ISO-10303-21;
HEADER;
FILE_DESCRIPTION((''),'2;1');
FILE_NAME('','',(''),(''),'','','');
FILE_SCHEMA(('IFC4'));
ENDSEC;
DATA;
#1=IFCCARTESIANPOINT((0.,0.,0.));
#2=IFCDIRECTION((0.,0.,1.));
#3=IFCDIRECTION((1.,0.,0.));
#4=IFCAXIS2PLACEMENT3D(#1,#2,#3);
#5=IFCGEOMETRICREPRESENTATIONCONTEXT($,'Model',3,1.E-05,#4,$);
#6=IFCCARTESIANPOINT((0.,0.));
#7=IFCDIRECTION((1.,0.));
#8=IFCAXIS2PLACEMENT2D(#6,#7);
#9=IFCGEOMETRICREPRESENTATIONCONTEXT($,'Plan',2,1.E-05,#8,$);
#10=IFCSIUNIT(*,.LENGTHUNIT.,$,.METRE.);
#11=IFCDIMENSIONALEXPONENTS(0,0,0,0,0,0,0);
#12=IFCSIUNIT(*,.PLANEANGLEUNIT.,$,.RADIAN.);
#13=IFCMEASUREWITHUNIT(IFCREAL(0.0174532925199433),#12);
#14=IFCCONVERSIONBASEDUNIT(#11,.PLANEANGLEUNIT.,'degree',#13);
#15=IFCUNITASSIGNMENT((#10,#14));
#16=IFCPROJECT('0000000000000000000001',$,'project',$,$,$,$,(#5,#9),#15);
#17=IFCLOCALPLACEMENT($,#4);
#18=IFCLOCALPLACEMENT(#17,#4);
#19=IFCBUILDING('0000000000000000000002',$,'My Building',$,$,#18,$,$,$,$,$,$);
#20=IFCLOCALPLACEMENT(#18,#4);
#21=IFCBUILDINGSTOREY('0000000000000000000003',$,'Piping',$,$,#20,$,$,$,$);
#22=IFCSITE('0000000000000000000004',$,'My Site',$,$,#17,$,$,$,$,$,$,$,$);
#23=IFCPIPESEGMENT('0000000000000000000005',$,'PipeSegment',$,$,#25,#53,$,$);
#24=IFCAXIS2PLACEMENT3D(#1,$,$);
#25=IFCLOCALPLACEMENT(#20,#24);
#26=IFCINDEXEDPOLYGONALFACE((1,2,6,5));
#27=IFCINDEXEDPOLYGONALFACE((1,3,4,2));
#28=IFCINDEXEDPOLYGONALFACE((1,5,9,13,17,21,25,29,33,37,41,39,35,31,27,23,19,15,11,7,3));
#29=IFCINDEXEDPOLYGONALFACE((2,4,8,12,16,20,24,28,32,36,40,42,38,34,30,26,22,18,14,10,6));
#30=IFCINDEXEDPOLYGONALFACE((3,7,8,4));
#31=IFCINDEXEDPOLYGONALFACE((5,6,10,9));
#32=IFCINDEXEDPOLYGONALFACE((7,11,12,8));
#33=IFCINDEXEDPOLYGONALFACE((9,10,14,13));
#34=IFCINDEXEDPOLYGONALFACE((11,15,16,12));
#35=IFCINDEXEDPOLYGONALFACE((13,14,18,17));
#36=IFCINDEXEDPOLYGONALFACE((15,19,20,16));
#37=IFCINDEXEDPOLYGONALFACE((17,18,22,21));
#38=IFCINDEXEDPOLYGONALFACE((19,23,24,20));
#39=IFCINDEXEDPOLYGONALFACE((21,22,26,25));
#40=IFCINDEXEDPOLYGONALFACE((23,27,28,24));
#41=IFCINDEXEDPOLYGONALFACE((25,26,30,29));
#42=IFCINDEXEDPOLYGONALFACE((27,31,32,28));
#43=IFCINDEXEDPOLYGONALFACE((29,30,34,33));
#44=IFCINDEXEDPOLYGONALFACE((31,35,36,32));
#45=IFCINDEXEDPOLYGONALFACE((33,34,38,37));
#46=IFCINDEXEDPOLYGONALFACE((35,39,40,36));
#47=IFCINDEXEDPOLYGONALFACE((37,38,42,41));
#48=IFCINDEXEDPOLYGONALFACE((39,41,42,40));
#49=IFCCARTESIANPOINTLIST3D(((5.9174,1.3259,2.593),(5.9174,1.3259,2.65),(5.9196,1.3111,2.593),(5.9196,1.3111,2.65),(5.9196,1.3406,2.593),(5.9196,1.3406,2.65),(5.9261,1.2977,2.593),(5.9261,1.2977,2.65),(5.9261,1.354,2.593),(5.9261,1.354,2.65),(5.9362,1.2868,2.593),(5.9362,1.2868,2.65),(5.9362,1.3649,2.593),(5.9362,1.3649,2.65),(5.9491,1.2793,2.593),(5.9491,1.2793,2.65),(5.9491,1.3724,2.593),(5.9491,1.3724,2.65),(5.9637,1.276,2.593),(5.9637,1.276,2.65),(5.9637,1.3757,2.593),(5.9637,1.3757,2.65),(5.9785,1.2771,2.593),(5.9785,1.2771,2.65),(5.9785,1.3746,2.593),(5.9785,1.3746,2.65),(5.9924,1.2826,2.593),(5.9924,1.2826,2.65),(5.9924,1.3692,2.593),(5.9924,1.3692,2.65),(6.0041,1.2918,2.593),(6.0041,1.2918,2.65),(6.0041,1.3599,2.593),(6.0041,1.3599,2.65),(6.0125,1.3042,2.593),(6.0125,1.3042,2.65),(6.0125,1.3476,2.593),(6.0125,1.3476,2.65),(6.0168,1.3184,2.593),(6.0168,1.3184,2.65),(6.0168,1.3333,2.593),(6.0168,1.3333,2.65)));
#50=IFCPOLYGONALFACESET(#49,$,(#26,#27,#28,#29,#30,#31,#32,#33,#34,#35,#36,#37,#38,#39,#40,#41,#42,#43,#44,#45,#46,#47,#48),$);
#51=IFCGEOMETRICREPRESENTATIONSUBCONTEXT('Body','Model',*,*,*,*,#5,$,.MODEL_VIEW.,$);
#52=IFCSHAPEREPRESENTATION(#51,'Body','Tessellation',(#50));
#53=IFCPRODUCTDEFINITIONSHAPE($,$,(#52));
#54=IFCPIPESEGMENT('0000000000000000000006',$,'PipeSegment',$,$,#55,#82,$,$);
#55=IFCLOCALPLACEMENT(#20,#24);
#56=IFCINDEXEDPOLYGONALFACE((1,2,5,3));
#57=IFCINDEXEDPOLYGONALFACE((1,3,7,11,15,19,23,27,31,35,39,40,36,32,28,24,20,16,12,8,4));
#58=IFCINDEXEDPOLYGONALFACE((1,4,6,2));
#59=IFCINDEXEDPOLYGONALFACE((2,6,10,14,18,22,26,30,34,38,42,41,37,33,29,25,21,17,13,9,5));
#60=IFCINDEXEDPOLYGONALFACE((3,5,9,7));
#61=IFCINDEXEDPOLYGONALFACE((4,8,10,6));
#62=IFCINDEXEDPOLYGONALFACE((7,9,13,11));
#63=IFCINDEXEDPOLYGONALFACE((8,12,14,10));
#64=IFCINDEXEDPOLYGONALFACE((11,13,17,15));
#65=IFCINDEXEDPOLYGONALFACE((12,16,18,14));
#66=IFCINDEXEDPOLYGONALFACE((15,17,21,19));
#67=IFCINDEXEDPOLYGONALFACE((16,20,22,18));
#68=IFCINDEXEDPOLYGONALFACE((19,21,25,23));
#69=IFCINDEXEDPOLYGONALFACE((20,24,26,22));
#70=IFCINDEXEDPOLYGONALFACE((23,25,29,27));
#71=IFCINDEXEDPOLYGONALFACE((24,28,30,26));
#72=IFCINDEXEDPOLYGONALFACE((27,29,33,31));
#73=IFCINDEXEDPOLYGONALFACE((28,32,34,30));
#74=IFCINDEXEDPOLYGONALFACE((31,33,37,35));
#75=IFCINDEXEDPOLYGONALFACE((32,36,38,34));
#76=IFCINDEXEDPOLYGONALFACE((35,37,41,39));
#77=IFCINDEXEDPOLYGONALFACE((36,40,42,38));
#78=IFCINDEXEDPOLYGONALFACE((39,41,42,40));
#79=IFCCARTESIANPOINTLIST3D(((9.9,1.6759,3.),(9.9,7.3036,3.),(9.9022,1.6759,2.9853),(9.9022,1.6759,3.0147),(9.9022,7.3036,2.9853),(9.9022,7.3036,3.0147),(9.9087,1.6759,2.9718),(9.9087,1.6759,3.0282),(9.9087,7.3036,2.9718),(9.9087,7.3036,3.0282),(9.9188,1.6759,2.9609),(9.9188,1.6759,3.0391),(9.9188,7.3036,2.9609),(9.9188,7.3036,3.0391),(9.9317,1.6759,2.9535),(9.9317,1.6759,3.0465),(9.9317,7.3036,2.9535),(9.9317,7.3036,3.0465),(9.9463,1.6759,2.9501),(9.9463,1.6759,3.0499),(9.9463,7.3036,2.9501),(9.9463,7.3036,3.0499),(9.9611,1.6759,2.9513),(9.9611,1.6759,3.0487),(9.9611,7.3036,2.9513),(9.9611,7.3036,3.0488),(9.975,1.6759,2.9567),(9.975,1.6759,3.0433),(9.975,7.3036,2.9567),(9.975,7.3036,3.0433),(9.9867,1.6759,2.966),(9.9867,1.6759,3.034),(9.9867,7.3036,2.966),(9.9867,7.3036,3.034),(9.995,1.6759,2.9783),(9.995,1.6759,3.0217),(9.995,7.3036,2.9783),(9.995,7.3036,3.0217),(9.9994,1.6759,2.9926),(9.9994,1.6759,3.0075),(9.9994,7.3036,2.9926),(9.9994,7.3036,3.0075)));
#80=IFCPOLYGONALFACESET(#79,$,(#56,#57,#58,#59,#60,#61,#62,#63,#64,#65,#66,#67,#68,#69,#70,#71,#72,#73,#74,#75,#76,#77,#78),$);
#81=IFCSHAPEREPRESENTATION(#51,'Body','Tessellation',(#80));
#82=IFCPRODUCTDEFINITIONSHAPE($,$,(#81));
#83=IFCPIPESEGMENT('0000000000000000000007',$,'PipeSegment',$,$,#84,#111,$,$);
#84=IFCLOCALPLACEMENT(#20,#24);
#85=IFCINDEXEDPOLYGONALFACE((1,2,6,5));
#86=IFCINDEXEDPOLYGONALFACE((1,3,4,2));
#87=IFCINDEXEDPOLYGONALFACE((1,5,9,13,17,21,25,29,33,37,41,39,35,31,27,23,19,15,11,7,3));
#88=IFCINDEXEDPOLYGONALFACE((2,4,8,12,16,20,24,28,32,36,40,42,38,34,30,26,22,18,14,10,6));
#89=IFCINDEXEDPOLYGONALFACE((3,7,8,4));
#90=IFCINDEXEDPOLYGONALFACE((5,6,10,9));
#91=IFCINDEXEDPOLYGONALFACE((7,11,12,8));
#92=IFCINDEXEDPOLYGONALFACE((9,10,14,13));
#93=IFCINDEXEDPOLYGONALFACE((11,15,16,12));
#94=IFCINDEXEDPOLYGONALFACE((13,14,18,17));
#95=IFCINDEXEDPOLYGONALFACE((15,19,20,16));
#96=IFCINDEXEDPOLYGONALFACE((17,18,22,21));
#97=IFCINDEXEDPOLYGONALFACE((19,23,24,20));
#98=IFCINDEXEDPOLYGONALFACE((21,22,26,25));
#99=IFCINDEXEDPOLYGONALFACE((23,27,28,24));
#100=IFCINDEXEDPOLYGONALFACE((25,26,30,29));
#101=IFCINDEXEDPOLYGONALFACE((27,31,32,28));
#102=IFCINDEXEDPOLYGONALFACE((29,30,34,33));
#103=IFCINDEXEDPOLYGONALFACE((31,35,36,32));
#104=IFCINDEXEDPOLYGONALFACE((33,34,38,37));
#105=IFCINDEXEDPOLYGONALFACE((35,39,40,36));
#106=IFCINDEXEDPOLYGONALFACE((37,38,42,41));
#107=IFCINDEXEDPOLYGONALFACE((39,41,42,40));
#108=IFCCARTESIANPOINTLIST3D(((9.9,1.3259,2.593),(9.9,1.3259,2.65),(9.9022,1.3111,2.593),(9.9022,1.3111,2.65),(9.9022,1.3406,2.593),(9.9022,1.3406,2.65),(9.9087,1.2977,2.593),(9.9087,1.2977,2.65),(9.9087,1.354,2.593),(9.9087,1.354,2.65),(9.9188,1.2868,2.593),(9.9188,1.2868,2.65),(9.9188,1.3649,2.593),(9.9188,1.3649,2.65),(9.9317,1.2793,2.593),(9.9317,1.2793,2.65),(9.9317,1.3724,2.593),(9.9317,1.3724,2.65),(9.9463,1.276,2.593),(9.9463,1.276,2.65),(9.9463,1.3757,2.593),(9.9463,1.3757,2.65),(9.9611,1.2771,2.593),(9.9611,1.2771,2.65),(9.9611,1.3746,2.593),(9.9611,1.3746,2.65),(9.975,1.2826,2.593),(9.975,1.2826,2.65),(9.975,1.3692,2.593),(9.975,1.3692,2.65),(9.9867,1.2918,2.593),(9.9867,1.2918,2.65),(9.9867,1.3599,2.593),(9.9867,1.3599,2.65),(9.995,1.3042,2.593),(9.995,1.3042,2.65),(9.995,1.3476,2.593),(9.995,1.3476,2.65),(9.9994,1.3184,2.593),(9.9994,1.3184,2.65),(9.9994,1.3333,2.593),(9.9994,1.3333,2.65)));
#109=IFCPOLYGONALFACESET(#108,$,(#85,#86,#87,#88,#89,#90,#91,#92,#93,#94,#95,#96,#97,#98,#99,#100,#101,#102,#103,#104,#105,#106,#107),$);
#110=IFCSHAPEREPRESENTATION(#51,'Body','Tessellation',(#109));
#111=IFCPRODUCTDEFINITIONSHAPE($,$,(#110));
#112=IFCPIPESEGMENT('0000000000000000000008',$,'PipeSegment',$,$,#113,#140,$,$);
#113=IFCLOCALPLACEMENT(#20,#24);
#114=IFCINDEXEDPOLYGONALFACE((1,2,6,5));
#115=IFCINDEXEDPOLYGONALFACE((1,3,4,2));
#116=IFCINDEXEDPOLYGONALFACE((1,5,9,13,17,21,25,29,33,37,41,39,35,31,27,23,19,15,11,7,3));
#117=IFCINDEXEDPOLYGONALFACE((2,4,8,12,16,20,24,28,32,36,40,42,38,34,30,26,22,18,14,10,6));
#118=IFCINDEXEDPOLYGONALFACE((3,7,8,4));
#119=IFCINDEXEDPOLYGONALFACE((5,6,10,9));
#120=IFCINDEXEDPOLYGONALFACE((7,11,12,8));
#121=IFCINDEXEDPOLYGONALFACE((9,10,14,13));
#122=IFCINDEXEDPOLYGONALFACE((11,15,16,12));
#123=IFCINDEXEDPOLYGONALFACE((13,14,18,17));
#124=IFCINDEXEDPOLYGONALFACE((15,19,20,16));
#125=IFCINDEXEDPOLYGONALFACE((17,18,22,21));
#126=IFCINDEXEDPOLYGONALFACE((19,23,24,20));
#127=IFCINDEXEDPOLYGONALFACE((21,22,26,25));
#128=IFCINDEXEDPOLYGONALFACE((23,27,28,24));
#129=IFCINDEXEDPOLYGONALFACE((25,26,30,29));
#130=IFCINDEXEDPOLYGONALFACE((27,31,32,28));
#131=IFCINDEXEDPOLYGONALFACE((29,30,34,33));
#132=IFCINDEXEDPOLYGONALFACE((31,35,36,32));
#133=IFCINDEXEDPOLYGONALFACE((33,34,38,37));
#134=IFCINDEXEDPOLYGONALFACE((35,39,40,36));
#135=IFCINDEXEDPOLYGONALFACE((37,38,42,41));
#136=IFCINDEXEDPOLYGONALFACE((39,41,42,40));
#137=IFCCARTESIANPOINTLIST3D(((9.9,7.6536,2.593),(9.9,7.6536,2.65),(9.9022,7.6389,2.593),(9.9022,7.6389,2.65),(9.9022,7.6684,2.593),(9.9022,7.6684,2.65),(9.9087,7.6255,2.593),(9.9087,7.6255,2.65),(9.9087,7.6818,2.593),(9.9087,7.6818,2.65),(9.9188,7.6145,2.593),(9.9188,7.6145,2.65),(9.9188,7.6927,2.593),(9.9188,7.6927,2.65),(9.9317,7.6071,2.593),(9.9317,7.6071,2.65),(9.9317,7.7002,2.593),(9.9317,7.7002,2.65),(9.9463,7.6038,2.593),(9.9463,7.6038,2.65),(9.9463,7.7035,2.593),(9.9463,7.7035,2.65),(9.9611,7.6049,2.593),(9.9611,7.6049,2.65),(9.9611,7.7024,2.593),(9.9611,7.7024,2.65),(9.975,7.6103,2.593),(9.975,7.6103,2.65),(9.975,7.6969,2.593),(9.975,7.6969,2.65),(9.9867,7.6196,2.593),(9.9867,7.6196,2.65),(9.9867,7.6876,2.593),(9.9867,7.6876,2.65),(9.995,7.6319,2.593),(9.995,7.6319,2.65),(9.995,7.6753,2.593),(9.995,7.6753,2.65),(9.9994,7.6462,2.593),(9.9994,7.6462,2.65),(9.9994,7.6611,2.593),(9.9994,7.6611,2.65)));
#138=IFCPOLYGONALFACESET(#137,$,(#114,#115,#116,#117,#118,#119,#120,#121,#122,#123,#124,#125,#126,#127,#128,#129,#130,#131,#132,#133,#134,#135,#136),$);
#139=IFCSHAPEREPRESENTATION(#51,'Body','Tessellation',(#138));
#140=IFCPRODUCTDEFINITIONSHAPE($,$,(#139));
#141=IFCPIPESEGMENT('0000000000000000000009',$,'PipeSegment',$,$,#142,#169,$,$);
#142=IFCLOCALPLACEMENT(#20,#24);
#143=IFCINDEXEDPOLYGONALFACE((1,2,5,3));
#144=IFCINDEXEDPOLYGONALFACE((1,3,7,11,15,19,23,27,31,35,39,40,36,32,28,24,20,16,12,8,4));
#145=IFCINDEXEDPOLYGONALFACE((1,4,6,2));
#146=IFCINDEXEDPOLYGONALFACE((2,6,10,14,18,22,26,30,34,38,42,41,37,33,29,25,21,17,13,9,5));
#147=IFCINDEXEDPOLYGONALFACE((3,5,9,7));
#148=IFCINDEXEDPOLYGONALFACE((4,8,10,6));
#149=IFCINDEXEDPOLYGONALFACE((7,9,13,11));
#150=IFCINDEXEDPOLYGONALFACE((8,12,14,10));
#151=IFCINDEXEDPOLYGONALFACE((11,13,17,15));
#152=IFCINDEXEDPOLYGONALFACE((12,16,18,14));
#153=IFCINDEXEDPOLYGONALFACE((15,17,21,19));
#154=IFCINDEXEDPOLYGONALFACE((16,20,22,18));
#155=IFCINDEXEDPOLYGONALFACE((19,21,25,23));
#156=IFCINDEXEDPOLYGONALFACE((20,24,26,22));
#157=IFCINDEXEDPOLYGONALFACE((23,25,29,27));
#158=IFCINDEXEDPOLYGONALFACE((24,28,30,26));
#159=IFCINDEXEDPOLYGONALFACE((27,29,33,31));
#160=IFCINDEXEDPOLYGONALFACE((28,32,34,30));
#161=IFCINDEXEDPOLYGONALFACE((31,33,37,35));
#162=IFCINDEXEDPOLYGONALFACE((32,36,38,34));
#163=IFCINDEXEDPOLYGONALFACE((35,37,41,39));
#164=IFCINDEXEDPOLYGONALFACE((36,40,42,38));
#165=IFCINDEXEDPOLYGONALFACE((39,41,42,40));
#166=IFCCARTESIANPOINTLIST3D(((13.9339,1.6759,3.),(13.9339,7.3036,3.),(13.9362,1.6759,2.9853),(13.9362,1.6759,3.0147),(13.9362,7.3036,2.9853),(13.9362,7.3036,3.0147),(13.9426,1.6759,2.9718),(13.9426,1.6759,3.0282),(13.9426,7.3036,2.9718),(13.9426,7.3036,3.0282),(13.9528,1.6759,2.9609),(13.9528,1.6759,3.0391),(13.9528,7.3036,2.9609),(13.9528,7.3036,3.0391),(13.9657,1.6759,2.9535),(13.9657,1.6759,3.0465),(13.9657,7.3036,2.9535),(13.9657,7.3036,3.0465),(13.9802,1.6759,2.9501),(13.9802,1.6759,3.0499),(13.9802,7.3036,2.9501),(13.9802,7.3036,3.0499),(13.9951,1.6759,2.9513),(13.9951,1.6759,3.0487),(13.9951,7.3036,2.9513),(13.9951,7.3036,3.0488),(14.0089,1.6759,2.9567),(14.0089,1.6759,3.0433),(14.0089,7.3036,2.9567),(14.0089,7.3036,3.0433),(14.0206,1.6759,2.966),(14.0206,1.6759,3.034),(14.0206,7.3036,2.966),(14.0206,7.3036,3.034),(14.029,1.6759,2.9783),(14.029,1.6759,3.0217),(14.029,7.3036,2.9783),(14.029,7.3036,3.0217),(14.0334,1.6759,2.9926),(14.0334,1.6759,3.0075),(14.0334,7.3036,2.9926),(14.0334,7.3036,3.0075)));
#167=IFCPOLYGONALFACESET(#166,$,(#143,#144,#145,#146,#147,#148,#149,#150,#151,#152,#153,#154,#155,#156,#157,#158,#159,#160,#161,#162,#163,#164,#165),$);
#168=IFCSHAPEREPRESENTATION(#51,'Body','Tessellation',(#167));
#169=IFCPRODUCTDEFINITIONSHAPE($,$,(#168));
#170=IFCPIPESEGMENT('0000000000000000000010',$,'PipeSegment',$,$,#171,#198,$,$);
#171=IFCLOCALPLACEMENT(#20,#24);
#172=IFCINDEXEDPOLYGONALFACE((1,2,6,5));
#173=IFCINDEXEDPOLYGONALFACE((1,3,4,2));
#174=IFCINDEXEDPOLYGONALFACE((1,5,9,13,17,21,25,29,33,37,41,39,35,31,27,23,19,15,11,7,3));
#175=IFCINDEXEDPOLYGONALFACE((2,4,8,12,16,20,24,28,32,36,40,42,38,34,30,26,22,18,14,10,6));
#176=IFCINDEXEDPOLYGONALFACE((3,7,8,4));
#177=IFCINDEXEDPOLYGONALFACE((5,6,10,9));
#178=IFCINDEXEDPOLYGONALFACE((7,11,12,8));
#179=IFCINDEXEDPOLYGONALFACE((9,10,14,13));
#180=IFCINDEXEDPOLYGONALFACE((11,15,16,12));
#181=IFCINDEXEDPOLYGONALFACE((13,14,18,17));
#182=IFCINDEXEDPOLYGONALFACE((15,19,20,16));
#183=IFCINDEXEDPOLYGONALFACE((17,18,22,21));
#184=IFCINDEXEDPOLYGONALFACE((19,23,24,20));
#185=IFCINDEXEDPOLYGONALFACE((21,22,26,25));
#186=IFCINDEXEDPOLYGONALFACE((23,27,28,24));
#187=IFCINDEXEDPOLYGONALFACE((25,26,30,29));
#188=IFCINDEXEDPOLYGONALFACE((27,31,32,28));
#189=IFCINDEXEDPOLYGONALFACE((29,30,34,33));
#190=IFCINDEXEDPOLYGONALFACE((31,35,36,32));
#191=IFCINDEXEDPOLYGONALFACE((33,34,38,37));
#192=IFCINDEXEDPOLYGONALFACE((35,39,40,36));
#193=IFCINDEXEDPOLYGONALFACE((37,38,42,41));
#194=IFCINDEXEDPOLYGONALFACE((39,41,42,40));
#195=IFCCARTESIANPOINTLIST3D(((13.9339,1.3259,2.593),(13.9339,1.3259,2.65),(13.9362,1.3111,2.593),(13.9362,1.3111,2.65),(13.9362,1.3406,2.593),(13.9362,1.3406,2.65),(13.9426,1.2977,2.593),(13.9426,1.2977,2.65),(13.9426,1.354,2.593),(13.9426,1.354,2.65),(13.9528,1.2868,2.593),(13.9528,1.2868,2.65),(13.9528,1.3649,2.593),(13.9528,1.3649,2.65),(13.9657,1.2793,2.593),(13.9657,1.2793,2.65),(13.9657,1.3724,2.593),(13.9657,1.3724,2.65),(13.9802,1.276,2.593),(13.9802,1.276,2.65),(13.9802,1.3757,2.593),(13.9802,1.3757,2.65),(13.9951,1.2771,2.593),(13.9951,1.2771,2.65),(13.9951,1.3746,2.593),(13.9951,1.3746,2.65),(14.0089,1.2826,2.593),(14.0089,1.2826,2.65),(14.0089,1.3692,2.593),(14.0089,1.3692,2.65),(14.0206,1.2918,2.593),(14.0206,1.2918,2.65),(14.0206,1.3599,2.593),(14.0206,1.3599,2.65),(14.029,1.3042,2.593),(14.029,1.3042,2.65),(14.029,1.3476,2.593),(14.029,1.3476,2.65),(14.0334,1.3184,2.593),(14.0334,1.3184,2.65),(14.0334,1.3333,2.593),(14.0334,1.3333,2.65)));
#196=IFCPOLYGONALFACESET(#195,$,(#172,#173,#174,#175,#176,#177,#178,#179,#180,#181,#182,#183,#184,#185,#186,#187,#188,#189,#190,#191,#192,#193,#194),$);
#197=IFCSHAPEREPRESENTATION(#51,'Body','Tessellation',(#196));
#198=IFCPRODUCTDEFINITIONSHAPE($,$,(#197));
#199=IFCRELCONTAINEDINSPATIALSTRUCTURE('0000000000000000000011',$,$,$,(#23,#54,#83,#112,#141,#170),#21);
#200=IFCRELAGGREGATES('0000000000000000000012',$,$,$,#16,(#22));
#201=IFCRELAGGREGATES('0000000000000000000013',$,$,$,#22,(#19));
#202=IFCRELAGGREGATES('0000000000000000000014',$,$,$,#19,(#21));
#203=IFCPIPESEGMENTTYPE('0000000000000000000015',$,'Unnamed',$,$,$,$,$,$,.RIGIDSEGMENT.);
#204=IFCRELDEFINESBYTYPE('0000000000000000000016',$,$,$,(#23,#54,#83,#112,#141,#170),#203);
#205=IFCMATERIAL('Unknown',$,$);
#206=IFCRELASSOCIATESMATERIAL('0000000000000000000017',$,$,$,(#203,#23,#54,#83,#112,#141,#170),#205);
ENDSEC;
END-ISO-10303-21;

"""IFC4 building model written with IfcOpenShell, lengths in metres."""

from ifc_helpers import new_model, entity, si_unit, converted_unit, frame, origin_with_axes, origin_2d_with_axis, place, context, subcontext, project, spatial, circle, extrude, material, material_profile, profile_set, profile_usage, type_object, element, save


model = new_model("IFC4")

# Units and contexts
model_context = context("Model", 3, precision=1e-05, world=origin_with_axes())
plan_context = context("Plan", 2, precision=1e-05, world=origin_2d_with_axis())
body_context = subcontext(model_context, "Body", "Model", "MODEL_VIEW")
ifc_project = project(units=[si_unit("LENGTHUNIT", "METRE"), converted_unit("PLANEANGLEUNIT", "degree", entity("IfcReal", 0.0174532925199433), si_unit("PLANEANGLEUNIT", "RADIAN"), dimensions=[0, 0, 0, 0, 0, 0, 0])], contexts=[model_context, plan_context])

# Site, building, storey
site_placement = place(None, origin_with_axes())
site = spatial("IfcSite", under=ifc_project, at=site_placement, Name="My Site")
building_placement = place(site_placement, origin_with_axes())
building = spatial("IfcBuilding", under=site, at=building_placement, Name="My Building")
storey_placement = place(building_placement, origin_with_axes())
storey = spatial("IfcBuildingStorey", under=building, at=storey_placement, Name="Piping")

# Pipe segments
ifc_material = material(Name="Unknown")
ifc_material_profile = material_profile(ifc_material, circle(Radius=0.05))
ifc_profile_set = profile_set([ifc_material_profile])
pipe_segment_type = type_object("IfcPipeSegmentType", Name="Unnamed", PredefinedType="RIGIDSEGMENT", material=ifc_profile_set)
ifc_profile_usage_1 = profile_usage(ifc_profile_set, cardinal=5)
pipe_segment_1_placement = place(storey_placement, frame((5.9674, 1.3259, 2.65), z_axis=(0.0, 0.0, -1.0), x_axis=(-1.0, 0.0, 0.0)))
element("IfcPipeSegment", 1, at=pipe_segment_1_placement, inside=storey, type_object=pipe_segment_type, material=ifc_profile_usage_1, Name="PipeSegment", context=body_context, shape_type="SweptSolid", body=[
    extrude(circle(Radius=0.05), origin_with_axes(), (0.0, 0.0, 1.0), 0.057),
])
ifc_profile_usage_2 = profile_usage(ifc_profile_set, cardinal=5)
pipe_segment_2_placement = place(storey_placement, frame((9.95, 1.6759, 3.0), z_axis=(0.0, 1.0, 0.0), x_axis=(-1.0, 0.0, 0.0)))
element("IfcPipeSegment", 2, at=pipe_segment_2_placement, inside=storey, type_object=pipe_segment_type, material=ifc_profile_usage_2, Name="PipeSegment", context=body_context, shape_type="SweptSolid", body=[
    extrude(circle(Radius=0.05), origin_with_axes(), (0.0, 0.0, 1.0), 5.6278),
])
ifc_profile_usage_3 = profile_usage(ifc_profile_set, cardinal=5)
pipe_segment_3_placement = place(storey_placement, frame((9.95, 1.3259, 2.65), z_axis=(0.0, 0.0, -1.0), x_axis=(-1.0, 0.0, 0.0)))
element("IfcPipeSegment", 3, at=pipe_segment_3_placement, inside=storey, type_object=pipe_segment_type, material=ifc_profile_usage_3, Name="PipeSegment", context=body_context, shape_type="SweptSolid", body=[
    extrude(circle(Radius=0.05), origin_with_axes(), (0.0, 0.0, 1.0), 0.057),
])
ifc_profile_usage_4 = profile_usage(ifc_profile_set, cardinal=5)
pipe_segment_4_placement = place(storey_placement, frame((9.95, 7.6536, 2.65), z_axis=(0.0, 0.0, -1.0), x_axis=(-1.0, 0.0, 0.0)))
element("IfcPipeSegment", 4, at=pipe_segment_4_placement, inside=storey, type_object=pipe_segment_type, material=ifc_profile_usage_4, Name="PipeSegment", context=body_context, shape_type="SweptSolid", body=[
    extrude(circle(Radius=0.05), origin_with_axes(), (0.0, 0.0, 1.0), 0.057),
])
ifc_profile_usage_5 = profile_usage(ifc_profile_set, cardinal=5)
pipe_segment_5_placement = place(storey_placement, frame((13.9839, 1.6759, 3.0), z_axis=(0.0, 1.0, 0.0), x_axis=(-1.0, 0.0, 0.0)))
element("IfcPipeSegment", 5, at=pipe_segment_5_placement, inside=storey, type_object=pipe_segment_type, material=ifc_profile_usage_5, Name="PipeSegment", context=body_context, shape_type="SweptSolid", body=[
    extrude(circle(Radius=0.05), origin_with_axes(), (0.0, 0.0, 1.0), 5.6278),
])
ifc_profile_usage_6 = profile_usage(ifc_profile_set, cardinal=5)
pipe_segment_6_placement = place(storey_placement, frame((13.9839, 1.3259, 2.65), z_axis=(0.0, 0.0, -1.0), x_axis=(-1.0, 0.0, 0.0)))
element("IfcPipeSegment", 6, at=pipe_segment_6_placement, inside=storey, type_object=pipe_segment_type, material=ifc_profile_usage_6, Name="PipeSegment", context=body_context, shape_type="SweptSolid", body=[
    extrude(circle(Radius=0.05), origin_with_axes(), (0.0, 0.0, 1.0), 0.057),
])

save(model, "model.ifc")
